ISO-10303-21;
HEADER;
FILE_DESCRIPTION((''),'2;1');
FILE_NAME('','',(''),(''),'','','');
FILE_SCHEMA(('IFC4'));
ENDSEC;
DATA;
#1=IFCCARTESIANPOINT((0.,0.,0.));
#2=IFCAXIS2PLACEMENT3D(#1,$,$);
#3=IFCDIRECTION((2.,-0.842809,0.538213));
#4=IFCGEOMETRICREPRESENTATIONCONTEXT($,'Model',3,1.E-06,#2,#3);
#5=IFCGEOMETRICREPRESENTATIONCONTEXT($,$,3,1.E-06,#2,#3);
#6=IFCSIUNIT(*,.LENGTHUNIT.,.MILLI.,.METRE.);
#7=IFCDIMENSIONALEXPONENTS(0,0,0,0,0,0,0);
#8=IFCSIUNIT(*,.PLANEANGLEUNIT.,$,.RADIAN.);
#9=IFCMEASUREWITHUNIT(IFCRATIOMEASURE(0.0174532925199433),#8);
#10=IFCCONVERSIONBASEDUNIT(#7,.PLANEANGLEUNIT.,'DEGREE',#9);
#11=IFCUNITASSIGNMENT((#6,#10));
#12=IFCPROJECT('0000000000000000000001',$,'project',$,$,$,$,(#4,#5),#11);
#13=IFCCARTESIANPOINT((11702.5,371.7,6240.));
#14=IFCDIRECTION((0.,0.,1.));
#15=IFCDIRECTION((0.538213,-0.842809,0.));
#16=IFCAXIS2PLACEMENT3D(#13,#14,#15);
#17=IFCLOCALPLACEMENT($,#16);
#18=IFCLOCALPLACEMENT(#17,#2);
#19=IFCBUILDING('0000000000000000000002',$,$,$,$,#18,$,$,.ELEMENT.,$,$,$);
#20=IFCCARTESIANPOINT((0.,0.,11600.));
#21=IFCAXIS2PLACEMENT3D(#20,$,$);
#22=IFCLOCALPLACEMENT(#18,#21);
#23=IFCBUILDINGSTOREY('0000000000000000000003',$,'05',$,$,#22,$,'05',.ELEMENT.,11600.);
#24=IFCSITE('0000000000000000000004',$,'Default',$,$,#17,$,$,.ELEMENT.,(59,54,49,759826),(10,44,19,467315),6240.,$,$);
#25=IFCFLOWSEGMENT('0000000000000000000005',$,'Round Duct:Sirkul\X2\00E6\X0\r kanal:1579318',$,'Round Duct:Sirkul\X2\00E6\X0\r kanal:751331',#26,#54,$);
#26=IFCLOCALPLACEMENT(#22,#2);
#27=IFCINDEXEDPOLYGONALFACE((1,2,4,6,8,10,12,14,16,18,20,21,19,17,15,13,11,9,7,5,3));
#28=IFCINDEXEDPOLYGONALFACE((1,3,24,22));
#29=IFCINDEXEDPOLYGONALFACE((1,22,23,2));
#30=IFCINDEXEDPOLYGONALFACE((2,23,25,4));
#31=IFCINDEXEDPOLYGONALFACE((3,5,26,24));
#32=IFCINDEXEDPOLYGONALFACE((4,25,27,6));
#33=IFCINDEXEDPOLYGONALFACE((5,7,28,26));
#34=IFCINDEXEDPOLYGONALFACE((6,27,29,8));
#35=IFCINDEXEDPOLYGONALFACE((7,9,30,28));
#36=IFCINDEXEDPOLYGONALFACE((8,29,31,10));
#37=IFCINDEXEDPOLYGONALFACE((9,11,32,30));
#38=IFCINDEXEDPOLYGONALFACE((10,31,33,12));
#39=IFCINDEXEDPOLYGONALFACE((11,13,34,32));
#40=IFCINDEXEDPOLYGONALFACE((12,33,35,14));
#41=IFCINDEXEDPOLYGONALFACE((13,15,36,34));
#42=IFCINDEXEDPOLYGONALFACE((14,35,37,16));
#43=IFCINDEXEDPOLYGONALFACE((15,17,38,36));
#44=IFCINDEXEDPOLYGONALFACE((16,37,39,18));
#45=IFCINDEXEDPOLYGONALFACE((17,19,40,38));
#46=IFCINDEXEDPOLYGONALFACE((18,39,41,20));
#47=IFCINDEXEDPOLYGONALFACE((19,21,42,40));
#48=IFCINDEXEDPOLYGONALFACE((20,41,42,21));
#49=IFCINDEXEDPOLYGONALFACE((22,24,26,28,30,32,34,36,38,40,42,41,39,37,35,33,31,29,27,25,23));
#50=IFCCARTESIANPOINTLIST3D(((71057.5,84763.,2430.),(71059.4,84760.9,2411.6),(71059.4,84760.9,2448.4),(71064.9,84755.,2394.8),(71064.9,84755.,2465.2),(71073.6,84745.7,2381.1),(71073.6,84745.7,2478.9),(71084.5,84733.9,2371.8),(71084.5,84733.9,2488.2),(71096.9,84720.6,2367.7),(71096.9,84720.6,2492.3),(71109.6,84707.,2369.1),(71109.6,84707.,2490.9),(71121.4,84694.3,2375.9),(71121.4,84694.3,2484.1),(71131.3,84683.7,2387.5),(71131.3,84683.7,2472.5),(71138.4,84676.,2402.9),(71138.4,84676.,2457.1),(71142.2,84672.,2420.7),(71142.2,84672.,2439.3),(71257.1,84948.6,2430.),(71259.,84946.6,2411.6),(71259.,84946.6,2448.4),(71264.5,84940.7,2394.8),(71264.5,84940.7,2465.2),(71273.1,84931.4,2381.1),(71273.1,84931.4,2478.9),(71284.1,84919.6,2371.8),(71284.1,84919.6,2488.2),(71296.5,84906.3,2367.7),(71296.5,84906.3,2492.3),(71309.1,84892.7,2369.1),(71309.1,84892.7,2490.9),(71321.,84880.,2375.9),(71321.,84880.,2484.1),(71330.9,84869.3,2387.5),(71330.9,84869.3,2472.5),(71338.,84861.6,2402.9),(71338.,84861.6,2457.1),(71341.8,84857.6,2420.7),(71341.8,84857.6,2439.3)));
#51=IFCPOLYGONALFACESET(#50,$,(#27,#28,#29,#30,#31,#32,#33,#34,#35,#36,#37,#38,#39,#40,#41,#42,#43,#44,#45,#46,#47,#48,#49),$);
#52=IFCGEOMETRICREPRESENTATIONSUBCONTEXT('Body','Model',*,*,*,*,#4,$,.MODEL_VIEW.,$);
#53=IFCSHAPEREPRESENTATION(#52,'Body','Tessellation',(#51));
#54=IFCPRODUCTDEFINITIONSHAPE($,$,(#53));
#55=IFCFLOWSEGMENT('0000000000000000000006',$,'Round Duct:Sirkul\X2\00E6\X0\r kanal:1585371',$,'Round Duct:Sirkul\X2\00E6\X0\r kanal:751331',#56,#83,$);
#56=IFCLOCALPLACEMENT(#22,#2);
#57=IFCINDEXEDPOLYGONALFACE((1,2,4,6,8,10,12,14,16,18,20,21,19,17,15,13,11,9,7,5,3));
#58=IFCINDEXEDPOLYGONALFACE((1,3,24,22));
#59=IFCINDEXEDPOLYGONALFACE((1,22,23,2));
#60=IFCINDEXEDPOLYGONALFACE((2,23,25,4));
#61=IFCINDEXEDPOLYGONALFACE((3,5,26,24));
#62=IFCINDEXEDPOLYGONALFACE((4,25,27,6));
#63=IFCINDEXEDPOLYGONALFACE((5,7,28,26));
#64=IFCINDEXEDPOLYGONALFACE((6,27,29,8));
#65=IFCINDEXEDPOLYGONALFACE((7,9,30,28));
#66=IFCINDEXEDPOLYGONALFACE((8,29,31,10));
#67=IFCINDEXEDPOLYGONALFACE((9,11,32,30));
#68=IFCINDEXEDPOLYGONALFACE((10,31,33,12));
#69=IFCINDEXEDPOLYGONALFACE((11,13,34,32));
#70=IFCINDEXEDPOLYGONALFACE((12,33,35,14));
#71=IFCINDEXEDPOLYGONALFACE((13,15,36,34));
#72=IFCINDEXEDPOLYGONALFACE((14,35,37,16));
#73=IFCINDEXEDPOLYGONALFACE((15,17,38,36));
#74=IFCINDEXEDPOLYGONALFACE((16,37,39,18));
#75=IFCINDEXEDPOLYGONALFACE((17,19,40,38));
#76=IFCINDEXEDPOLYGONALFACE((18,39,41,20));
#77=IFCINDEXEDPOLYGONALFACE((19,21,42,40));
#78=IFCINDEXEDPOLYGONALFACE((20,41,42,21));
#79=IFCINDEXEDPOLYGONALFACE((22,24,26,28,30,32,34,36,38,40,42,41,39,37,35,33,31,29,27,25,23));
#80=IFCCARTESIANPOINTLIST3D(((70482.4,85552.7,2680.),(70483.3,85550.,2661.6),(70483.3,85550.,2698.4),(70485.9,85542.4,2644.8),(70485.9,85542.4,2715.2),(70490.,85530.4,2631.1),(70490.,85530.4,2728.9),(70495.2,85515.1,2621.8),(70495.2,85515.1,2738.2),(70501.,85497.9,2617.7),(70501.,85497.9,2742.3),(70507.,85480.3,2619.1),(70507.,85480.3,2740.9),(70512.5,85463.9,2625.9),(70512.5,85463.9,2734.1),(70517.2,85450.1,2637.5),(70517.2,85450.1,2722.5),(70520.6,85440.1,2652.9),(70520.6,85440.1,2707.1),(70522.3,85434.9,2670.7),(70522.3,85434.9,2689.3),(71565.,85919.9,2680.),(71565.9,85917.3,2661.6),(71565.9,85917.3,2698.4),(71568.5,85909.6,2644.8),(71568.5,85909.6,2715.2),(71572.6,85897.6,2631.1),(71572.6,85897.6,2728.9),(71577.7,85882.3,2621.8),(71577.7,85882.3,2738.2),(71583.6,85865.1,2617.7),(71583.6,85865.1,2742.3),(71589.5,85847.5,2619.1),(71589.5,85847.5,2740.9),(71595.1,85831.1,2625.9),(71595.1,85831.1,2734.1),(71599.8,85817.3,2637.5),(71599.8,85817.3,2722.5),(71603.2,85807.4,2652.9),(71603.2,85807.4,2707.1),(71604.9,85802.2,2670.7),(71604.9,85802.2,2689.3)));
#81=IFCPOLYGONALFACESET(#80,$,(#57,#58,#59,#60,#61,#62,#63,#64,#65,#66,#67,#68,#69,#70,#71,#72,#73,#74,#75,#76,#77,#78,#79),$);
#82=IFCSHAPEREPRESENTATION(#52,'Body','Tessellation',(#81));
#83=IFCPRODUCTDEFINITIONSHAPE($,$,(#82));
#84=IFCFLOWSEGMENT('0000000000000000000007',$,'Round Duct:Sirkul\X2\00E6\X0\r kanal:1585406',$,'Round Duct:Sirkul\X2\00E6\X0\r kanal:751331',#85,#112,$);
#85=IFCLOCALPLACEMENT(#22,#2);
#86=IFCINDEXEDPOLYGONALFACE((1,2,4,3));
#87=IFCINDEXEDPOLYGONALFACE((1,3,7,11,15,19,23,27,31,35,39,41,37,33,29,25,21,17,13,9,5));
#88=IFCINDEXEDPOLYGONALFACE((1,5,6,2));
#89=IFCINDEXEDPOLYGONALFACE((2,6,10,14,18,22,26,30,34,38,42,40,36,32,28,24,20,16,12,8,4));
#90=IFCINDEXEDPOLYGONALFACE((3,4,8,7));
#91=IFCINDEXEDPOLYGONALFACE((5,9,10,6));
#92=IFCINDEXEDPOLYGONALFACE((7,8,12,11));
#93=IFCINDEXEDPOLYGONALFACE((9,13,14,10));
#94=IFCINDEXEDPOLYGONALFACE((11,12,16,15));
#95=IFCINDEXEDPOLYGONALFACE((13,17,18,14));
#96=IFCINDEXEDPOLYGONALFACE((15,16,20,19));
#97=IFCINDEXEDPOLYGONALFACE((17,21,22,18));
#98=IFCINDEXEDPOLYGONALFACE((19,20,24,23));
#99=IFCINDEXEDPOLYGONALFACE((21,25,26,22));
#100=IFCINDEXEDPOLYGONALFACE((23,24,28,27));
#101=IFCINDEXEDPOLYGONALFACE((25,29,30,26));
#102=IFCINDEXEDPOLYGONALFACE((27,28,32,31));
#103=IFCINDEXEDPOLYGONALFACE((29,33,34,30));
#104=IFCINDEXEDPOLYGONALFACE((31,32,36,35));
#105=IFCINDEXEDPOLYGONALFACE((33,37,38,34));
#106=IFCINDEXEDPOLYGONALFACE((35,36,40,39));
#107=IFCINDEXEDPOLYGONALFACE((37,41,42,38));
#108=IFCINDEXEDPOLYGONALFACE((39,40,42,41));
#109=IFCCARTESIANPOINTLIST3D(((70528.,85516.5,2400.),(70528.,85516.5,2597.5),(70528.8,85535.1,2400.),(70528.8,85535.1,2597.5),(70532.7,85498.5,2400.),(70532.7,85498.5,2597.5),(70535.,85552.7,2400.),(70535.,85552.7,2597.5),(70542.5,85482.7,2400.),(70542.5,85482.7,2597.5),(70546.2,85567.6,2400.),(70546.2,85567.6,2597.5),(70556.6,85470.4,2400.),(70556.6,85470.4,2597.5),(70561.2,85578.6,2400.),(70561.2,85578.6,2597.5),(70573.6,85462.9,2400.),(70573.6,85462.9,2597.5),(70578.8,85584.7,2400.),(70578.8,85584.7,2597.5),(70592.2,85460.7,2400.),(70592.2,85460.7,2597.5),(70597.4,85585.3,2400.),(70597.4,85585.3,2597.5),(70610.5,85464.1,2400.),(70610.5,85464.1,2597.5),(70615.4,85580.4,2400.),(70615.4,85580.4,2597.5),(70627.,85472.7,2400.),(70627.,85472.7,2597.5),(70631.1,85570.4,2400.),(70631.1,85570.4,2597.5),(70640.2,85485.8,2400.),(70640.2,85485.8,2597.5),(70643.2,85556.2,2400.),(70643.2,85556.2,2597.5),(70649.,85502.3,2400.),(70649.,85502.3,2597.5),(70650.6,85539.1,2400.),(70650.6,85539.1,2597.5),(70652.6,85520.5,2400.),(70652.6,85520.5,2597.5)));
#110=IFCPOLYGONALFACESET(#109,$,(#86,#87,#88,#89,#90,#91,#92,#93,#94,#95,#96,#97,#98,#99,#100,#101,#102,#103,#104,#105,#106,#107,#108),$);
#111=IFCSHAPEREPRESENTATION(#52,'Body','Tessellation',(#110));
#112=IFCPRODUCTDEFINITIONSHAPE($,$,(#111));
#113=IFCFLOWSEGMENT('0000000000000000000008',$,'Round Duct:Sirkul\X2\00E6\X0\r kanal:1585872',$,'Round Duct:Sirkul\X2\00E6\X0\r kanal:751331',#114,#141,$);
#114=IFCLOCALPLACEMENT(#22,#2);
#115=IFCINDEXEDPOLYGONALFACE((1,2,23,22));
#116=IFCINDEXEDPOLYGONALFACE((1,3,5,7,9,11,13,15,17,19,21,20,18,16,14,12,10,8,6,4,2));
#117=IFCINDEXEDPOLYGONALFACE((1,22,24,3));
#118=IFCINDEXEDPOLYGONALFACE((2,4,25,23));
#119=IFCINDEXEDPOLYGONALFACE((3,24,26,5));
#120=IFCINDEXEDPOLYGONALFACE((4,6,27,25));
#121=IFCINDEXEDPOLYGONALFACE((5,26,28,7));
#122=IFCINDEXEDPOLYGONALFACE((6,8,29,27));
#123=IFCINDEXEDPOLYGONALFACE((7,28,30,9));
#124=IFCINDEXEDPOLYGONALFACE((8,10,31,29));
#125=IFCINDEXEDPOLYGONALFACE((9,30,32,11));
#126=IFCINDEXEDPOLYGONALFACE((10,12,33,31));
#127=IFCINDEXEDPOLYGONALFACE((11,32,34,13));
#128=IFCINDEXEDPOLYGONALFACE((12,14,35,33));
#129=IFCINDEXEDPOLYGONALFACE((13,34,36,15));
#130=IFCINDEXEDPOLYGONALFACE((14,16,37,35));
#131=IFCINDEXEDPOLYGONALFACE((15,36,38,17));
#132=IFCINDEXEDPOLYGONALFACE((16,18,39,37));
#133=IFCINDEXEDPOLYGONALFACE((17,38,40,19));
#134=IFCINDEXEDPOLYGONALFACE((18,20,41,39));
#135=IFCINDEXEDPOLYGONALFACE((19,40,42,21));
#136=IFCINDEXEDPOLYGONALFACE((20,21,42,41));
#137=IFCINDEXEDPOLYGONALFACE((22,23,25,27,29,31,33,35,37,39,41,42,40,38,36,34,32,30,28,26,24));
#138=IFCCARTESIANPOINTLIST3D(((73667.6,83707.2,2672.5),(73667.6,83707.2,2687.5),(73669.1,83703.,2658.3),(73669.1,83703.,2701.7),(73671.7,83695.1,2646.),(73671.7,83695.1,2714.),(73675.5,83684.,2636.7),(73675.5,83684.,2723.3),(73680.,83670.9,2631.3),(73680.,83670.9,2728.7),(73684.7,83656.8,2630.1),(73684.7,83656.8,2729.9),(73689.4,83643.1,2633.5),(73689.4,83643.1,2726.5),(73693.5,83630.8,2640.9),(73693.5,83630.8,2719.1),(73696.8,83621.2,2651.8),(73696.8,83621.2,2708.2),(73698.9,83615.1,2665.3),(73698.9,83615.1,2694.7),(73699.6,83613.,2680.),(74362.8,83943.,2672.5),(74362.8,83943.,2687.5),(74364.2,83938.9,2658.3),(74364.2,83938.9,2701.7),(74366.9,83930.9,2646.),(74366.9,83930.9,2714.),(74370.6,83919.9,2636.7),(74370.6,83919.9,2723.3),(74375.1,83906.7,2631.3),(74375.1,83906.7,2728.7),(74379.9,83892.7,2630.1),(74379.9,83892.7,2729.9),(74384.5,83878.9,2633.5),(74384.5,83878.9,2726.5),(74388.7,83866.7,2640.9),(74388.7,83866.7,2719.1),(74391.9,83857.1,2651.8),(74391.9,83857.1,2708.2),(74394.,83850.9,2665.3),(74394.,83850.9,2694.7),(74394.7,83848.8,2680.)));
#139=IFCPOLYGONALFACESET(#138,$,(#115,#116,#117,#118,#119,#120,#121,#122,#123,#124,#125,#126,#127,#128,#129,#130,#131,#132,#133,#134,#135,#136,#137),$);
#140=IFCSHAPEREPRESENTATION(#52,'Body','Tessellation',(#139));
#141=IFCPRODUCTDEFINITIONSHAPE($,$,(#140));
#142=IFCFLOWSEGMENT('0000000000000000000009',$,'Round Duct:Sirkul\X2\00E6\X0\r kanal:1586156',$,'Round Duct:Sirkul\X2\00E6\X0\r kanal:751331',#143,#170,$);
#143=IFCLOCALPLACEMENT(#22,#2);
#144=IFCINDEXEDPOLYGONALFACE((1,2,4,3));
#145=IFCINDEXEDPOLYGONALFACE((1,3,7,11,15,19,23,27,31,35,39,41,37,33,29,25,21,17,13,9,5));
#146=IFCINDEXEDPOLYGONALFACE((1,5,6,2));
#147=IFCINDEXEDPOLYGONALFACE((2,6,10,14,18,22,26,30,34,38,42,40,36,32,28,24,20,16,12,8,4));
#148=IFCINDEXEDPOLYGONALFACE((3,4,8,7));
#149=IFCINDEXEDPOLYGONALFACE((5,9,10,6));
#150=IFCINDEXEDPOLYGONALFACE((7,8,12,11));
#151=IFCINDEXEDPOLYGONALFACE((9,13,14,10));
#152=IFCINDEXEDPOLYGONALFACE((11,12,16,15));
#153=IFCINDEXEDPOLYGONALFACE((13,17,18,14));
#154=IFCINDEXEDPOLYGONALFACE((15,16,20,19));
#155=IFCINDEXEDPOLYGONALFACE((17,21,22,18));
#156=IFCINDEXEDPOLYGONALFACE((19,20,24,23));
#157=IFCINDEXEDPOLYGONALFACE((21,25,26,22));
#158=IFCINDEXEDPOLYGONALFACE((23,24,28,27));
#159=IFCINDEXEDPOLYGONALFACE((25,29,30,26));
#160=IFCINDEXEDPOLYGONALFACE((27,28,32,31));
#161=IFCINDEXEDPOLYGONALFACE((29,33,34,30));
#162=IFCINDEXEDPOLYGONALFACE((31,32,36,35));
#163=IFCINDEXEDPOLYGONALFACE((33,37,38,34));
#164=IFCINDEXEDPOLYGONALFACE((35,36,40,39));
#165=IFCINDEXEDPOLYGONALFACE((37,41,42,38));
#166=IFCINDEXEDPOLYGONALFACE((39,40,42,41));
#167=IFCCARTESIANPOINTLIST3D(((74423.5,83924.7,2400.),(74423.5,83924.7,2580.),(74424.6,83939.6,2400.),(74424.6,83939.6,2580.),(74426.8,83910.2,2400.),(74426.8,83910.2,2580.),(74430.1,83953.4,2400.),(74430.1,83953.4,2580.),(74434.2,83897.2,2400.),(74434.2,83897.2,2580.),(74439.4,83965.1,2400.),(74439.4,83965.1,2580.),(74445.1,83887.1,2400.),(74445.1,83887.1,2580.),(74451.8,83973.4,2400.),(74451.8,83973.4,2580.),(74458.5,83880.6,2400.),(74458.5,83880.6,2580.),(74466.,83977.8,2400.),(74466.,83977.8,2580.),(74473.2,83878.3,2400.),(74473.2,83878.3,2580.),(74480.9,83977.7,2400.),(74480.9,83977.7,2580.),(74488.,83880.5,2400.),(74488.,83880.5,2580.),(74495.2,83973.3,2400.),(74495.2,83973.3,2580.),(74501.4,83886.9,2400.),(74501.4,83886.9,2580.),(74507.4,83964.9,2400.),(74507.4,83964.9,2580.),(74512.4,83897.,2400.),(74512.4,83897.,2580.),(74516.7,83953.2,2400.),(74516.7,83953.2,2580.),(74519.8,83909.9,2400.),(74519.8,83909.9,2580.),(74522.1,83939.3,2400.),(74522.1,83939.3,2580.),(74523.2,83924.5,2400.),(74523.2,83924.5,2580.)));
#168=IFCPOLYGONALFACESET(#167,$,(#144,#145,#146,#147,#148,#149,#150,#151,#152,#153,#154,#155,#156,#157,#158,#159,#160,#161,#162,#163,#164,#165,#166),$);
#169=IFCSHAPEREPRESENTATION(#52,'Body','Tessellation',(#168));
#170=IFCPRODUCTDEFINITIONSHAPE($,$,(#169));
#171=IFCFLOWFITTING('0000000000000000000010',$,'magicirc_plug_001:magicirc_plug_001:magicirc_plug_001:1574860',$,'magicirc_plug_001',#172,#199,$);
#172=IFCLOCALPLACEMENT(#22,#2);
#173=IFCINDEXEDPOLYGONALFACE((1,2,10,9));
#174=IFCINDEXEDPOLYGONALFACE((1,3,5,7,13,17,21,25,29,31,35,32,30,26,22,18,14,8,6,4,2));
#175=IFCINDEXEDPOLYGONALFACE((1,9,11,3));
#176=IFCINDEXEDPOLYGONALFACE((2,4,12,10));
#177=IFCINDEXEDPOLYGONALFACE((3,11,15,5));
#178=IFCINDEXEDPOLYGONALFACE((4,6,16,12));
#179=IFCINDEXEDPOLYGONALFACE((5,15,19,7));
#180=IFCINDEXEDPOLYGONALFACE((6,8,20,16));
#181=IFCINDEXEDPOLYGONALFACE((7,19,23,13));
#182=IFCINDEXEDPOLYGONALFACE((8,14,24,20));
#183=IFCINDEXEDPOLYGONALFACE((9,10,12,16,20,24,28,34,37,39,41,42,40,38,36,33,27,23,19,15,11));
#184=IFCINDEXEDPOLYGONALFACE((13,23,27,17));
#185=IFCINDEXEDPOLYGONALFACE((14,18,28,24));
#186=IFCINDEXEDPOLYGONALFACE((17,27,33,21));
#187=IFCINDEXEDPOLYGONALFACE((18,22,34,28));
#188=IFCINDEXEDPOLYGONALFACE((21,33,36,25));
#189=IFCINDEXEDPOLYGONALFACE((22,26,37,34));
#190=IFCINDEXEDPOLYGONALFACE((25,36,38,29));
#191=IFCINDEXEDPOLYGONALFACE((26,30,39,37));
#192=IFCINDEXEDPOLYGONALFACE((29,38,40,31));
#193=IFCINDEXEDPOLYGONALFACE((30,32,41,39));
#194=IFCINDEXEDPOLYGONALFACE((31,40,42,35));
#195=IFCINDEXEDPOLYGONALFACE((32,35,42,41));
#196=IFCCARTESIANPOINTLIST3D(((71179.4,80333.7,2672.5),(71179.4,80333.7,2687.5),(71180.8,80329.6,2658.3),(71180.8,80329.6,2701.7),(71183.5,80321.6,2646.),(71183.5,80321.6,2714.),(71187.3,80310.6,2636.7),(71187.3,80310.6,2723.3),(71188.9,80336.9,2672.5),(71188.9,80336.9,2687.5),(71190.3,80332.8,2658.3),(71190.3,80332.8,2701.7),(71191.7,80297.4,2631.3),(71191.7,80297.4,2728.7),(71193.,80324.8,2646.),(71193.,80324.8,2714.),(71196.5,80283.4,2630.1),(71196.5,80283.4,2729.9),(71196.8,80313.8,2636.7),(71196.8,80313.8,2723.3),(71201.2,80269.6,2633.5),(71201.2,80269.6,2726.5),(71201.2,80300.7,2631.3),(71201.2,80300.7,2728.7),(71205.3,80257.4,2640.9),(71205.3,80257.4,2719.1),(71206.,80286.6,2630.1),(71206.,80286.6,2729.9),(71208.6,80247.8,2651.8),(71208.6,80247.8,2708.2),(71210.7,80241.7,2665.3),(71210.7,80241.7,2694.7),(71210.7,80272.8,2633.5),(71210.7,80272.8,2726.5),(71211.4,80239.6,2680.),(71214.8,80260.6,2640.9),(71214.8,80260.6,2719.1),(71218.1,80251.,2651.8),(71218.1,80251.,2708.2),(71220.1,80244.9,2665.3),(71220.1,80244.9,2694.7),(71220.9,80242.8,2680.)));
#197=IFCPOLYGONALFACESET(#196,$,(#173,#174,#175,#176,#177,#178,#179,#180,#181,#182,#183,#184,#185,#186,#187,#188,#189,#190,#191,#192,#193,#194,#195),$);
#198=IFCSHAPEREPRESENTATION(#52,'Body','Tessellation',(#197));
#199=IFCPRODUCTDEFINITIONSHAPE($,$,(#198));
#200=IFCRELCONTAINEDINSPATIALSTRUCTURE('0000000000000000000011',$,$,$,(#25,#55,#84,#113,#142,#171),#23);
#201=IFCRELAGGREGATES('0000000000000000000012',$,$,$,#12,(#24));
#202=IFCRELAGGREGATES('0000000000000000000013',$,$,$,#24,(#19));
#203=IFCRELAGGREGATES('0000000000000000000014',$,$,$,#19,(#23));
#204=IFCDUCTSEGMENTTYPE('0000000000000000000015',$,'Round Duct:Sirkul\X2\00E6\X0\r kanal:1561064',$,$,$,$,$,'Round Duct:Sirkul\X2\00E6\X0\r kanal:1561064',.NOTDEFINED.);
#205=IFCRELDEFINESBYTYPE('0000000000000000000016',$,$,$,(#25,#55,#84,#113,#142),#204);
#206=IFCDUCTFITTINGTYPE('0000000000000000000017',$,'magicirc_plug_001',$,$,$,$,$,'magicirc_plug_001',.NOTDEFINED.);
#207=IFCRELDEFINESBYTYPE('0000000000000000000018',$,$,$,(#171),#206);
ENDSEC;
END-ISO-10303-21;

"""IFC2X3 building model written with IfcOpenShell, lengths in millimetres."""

from ifc_helpers import new_model, entity, si_unit, converted_unit, direction, frame, frame_2d, origin, origin_2d_with_axis, place, context, subcontext, project, spatial, circle, extrude, source, transform, mapped, type_object, type_shapes, element, save


model = new_model("IFC2X3")

# Units and contexts
model_context = context("Model", 3, precision=1e-06, world=origin(), true_north=direction((2.0, -0.842809, 0.538213)))
context_of_model = context(None, 3, precision=1e-06, world=origin(), true_north=direction((2.0, -0.842809, 0.538213)))
body_context = subcontext(model_context, "Body", "Model", "MODEL_VIEW")
ifc_project = project(units=[si_unit("LENGTHUNIT", "METRE", prefix="MILLI"), converted_unit("PLANEANGLEUNIT", "DEGREE", entity("IfcRatioMeasure", 0.0174532925199433), si_unit("PLANEANGLEUNIT", "RADIAN"), dimensions=[0, 0, 0, 0, 0, 0, 0])], contexts=[model_context, context_of_model])

# Site, building, storey
site_placement = place(None, frame((11702.5, 371.7, 6240.0), z_axis=(0.0, 0.0, 1.0), x_axis=(0.538213, -0.842809, 0.0)))
site = spatial("IfcSite", under=ifc_project, at=site_placement, Name="Default", CompositionType="ELEMENT", RefLatitude=(59, 54, 49, 759826), RefLongitude=(10, 44, 19, 467315), RefElevation=6240.0)
building_placement = place(site_placement, origin())
building = spatial("IfcBuilding", under=site, at=building_placement, CompositionType="ELEMENT")
storey_placement = place(building_placement, frame((0.0, 0.0, 11600.0)))
storey = spatial("IfcBuildingStorey", under=building, at=storey_placement, Name="05", LongName="05", CompositionType="ELEMENT", Elevation=11600.0)

# Flow segments
duct_segment_type = type_object("IfcDuctSegmentType", Name="Round Duct:Sirkulær kanal:1561064", ElementType="Round Duct:Sirkulær kanal:1561064", PredefinedType="NOTDEFINED")
flow_segment_1_placement = place(storey_placement, origin())
element("IfcFlowSegment", 1, at=flow_segment_1_placement, inside=storey, type_object=duct_segment_type, Name="Round Duct:Sirkulær kanal:1579318", ObjectType="Round Duct:Sirkulær kanal:751331", context=body_context, shape_type="SweptSolid", body=[
    extrude(circle(Radius=62.5, at=origin_2d_with_axis()), frame((71100.1, 84717.2, 2430.0), z_axis=(0.732163, 0.68113, 0.0), x_axis=(-0.68113, 0.732163, 0.0)), (0.0, 0.0, 1.0), 272.6),
])
flow_segment_2_placement = place(storey_placement, origin())
element("IfcFlowSegment", 2, at=flow_segment_2_placement, inside=storey, type_object=duct_segment_type, Name="Round Duct:Sirkulær kanal:1585371", ObjectType="Round Duct:Sirkulær kanal:751331", context=body_context, shape_type="SweptSolid", body=[
    extrude(circle(Radius=62.5, at=origin_2d_with_axis()), frame((70502.5, 85493.5, 2680.0), z_axis=(0.946996, 0.321245, 0.0), x_axis=(-0.321245, 0.946996, 0.0)), (0.0, 0.0, 1.0), 1143.2),
])
flow_segment_3_placement = place(storey_placement, origin())
element("IfcFlowSegment", 3, at=flow_segment_3_placement, inside=storey, type_object=duct_segment_type, Name="Round Duct:Sirkulær kanal:1585406", ObjectType="Round Duct:Sirkulær kanal:751331", context=body_context, shape_type="SweptSolid", body=[
    extrude(circle(Radius=62.5, at=origin_2d_with_axis()), frame((70590.1, 85523.2, 2400.0), z_axis=(0.0, 0.0, 1.0), x_axis=(0.325568, -0.945519, 0.0)), (0.0, 0.0, 1.0), 197.5),
])
flow_segment_4_placement = place(storey_placement, origin())
element("IfcFlowSegment", 4, at=flow_segment_4_placement, inside=storey, type_object=duct_segment_type, Name="Round Duct:Sirkulær kanal:1585872", ObjectType="Round Duct:Sirkulær kanal:751331", context=body_context, shape_type="SweptSolid", body=[
    extrude(circle(Radius=50.0, at=origin_2d_with_axis()), frame((73683.5, 83660.4, 2680.0), z_axis=(0.946986, 0.321274, 0.0), x_axis=(0.321274, -0.946986, 0.0)), (0.0, 0.0, 1.0), 734.0),
])
flow_segment_5_placement = place(storey_placement, origin())
element("IfcFlowSegment", 5, at=flow_segment_5_placement, inside=storey, type_object=duct_segment_type, Name="Round Duct:Sirkulær kanal:1586156", ObjectType="Round Duct:Sirkulær kanal:751331", context=body_context, shape_type="SweptSolid", body=[
    extrude(circle(Radius=50.0, at=frame_2d((0.0, 0.0), x_axis=(1.0, 0.0))), frame((74473.3, 83928.3, 2400.0), z_axis=(0.0, 0.0, 1.0), x_axis=(0.292372, -0.956305, 0.0)), (0.0, 0.0, 1.0), 180.0),
])

# Flow fitting
duct_fitting_type_1 = type_object("IfcDuctFittingType", Name="magicirc_plug_001", ElementType="magicirc_plug_001", PredefinedType="NOTDEFINED")
shared_shape_1 = source(origin(), body_context, "Body", "SweptSolid", [
    extrude(circle(Radius=50.0, at=frame_2d((0.0, 0.0), x_axis=(1.0, 0.0))), frame((0.0, 0.0, 0.0), z_axis=(1.0, 0.0, 0.0), x_axis=(0.0, 1.0, 0.0)), (0.0, 0.0, 1.0), 10.0),
])
type_shapes(duct_fitting_type_1, [shared_shape_1])
flow_fitting_placement = place(storey_placement, frame((71204.8, 80290.1, 2680.0), z_axis=(0.0, 0.0, 1.0), x_axis=(-0.946986, -0.321274, 0.0)))
element("IfcFlowFitting", 6, at=flow_fitting_placement, inside=storey, type_object=duct_fitting_type_1, Name="magicirc_plug_001:magicirc_plug_001:magicirc_plug_001:1574860", ObjectType="magicirc_plug_001", context=body_context, shape_type="MappedRepresentation", body=[
    mapped(shared_shape_1, transform((0.0, 0.0, 0.0), scale=1.0)),
])

save(model, "model.ifc")
